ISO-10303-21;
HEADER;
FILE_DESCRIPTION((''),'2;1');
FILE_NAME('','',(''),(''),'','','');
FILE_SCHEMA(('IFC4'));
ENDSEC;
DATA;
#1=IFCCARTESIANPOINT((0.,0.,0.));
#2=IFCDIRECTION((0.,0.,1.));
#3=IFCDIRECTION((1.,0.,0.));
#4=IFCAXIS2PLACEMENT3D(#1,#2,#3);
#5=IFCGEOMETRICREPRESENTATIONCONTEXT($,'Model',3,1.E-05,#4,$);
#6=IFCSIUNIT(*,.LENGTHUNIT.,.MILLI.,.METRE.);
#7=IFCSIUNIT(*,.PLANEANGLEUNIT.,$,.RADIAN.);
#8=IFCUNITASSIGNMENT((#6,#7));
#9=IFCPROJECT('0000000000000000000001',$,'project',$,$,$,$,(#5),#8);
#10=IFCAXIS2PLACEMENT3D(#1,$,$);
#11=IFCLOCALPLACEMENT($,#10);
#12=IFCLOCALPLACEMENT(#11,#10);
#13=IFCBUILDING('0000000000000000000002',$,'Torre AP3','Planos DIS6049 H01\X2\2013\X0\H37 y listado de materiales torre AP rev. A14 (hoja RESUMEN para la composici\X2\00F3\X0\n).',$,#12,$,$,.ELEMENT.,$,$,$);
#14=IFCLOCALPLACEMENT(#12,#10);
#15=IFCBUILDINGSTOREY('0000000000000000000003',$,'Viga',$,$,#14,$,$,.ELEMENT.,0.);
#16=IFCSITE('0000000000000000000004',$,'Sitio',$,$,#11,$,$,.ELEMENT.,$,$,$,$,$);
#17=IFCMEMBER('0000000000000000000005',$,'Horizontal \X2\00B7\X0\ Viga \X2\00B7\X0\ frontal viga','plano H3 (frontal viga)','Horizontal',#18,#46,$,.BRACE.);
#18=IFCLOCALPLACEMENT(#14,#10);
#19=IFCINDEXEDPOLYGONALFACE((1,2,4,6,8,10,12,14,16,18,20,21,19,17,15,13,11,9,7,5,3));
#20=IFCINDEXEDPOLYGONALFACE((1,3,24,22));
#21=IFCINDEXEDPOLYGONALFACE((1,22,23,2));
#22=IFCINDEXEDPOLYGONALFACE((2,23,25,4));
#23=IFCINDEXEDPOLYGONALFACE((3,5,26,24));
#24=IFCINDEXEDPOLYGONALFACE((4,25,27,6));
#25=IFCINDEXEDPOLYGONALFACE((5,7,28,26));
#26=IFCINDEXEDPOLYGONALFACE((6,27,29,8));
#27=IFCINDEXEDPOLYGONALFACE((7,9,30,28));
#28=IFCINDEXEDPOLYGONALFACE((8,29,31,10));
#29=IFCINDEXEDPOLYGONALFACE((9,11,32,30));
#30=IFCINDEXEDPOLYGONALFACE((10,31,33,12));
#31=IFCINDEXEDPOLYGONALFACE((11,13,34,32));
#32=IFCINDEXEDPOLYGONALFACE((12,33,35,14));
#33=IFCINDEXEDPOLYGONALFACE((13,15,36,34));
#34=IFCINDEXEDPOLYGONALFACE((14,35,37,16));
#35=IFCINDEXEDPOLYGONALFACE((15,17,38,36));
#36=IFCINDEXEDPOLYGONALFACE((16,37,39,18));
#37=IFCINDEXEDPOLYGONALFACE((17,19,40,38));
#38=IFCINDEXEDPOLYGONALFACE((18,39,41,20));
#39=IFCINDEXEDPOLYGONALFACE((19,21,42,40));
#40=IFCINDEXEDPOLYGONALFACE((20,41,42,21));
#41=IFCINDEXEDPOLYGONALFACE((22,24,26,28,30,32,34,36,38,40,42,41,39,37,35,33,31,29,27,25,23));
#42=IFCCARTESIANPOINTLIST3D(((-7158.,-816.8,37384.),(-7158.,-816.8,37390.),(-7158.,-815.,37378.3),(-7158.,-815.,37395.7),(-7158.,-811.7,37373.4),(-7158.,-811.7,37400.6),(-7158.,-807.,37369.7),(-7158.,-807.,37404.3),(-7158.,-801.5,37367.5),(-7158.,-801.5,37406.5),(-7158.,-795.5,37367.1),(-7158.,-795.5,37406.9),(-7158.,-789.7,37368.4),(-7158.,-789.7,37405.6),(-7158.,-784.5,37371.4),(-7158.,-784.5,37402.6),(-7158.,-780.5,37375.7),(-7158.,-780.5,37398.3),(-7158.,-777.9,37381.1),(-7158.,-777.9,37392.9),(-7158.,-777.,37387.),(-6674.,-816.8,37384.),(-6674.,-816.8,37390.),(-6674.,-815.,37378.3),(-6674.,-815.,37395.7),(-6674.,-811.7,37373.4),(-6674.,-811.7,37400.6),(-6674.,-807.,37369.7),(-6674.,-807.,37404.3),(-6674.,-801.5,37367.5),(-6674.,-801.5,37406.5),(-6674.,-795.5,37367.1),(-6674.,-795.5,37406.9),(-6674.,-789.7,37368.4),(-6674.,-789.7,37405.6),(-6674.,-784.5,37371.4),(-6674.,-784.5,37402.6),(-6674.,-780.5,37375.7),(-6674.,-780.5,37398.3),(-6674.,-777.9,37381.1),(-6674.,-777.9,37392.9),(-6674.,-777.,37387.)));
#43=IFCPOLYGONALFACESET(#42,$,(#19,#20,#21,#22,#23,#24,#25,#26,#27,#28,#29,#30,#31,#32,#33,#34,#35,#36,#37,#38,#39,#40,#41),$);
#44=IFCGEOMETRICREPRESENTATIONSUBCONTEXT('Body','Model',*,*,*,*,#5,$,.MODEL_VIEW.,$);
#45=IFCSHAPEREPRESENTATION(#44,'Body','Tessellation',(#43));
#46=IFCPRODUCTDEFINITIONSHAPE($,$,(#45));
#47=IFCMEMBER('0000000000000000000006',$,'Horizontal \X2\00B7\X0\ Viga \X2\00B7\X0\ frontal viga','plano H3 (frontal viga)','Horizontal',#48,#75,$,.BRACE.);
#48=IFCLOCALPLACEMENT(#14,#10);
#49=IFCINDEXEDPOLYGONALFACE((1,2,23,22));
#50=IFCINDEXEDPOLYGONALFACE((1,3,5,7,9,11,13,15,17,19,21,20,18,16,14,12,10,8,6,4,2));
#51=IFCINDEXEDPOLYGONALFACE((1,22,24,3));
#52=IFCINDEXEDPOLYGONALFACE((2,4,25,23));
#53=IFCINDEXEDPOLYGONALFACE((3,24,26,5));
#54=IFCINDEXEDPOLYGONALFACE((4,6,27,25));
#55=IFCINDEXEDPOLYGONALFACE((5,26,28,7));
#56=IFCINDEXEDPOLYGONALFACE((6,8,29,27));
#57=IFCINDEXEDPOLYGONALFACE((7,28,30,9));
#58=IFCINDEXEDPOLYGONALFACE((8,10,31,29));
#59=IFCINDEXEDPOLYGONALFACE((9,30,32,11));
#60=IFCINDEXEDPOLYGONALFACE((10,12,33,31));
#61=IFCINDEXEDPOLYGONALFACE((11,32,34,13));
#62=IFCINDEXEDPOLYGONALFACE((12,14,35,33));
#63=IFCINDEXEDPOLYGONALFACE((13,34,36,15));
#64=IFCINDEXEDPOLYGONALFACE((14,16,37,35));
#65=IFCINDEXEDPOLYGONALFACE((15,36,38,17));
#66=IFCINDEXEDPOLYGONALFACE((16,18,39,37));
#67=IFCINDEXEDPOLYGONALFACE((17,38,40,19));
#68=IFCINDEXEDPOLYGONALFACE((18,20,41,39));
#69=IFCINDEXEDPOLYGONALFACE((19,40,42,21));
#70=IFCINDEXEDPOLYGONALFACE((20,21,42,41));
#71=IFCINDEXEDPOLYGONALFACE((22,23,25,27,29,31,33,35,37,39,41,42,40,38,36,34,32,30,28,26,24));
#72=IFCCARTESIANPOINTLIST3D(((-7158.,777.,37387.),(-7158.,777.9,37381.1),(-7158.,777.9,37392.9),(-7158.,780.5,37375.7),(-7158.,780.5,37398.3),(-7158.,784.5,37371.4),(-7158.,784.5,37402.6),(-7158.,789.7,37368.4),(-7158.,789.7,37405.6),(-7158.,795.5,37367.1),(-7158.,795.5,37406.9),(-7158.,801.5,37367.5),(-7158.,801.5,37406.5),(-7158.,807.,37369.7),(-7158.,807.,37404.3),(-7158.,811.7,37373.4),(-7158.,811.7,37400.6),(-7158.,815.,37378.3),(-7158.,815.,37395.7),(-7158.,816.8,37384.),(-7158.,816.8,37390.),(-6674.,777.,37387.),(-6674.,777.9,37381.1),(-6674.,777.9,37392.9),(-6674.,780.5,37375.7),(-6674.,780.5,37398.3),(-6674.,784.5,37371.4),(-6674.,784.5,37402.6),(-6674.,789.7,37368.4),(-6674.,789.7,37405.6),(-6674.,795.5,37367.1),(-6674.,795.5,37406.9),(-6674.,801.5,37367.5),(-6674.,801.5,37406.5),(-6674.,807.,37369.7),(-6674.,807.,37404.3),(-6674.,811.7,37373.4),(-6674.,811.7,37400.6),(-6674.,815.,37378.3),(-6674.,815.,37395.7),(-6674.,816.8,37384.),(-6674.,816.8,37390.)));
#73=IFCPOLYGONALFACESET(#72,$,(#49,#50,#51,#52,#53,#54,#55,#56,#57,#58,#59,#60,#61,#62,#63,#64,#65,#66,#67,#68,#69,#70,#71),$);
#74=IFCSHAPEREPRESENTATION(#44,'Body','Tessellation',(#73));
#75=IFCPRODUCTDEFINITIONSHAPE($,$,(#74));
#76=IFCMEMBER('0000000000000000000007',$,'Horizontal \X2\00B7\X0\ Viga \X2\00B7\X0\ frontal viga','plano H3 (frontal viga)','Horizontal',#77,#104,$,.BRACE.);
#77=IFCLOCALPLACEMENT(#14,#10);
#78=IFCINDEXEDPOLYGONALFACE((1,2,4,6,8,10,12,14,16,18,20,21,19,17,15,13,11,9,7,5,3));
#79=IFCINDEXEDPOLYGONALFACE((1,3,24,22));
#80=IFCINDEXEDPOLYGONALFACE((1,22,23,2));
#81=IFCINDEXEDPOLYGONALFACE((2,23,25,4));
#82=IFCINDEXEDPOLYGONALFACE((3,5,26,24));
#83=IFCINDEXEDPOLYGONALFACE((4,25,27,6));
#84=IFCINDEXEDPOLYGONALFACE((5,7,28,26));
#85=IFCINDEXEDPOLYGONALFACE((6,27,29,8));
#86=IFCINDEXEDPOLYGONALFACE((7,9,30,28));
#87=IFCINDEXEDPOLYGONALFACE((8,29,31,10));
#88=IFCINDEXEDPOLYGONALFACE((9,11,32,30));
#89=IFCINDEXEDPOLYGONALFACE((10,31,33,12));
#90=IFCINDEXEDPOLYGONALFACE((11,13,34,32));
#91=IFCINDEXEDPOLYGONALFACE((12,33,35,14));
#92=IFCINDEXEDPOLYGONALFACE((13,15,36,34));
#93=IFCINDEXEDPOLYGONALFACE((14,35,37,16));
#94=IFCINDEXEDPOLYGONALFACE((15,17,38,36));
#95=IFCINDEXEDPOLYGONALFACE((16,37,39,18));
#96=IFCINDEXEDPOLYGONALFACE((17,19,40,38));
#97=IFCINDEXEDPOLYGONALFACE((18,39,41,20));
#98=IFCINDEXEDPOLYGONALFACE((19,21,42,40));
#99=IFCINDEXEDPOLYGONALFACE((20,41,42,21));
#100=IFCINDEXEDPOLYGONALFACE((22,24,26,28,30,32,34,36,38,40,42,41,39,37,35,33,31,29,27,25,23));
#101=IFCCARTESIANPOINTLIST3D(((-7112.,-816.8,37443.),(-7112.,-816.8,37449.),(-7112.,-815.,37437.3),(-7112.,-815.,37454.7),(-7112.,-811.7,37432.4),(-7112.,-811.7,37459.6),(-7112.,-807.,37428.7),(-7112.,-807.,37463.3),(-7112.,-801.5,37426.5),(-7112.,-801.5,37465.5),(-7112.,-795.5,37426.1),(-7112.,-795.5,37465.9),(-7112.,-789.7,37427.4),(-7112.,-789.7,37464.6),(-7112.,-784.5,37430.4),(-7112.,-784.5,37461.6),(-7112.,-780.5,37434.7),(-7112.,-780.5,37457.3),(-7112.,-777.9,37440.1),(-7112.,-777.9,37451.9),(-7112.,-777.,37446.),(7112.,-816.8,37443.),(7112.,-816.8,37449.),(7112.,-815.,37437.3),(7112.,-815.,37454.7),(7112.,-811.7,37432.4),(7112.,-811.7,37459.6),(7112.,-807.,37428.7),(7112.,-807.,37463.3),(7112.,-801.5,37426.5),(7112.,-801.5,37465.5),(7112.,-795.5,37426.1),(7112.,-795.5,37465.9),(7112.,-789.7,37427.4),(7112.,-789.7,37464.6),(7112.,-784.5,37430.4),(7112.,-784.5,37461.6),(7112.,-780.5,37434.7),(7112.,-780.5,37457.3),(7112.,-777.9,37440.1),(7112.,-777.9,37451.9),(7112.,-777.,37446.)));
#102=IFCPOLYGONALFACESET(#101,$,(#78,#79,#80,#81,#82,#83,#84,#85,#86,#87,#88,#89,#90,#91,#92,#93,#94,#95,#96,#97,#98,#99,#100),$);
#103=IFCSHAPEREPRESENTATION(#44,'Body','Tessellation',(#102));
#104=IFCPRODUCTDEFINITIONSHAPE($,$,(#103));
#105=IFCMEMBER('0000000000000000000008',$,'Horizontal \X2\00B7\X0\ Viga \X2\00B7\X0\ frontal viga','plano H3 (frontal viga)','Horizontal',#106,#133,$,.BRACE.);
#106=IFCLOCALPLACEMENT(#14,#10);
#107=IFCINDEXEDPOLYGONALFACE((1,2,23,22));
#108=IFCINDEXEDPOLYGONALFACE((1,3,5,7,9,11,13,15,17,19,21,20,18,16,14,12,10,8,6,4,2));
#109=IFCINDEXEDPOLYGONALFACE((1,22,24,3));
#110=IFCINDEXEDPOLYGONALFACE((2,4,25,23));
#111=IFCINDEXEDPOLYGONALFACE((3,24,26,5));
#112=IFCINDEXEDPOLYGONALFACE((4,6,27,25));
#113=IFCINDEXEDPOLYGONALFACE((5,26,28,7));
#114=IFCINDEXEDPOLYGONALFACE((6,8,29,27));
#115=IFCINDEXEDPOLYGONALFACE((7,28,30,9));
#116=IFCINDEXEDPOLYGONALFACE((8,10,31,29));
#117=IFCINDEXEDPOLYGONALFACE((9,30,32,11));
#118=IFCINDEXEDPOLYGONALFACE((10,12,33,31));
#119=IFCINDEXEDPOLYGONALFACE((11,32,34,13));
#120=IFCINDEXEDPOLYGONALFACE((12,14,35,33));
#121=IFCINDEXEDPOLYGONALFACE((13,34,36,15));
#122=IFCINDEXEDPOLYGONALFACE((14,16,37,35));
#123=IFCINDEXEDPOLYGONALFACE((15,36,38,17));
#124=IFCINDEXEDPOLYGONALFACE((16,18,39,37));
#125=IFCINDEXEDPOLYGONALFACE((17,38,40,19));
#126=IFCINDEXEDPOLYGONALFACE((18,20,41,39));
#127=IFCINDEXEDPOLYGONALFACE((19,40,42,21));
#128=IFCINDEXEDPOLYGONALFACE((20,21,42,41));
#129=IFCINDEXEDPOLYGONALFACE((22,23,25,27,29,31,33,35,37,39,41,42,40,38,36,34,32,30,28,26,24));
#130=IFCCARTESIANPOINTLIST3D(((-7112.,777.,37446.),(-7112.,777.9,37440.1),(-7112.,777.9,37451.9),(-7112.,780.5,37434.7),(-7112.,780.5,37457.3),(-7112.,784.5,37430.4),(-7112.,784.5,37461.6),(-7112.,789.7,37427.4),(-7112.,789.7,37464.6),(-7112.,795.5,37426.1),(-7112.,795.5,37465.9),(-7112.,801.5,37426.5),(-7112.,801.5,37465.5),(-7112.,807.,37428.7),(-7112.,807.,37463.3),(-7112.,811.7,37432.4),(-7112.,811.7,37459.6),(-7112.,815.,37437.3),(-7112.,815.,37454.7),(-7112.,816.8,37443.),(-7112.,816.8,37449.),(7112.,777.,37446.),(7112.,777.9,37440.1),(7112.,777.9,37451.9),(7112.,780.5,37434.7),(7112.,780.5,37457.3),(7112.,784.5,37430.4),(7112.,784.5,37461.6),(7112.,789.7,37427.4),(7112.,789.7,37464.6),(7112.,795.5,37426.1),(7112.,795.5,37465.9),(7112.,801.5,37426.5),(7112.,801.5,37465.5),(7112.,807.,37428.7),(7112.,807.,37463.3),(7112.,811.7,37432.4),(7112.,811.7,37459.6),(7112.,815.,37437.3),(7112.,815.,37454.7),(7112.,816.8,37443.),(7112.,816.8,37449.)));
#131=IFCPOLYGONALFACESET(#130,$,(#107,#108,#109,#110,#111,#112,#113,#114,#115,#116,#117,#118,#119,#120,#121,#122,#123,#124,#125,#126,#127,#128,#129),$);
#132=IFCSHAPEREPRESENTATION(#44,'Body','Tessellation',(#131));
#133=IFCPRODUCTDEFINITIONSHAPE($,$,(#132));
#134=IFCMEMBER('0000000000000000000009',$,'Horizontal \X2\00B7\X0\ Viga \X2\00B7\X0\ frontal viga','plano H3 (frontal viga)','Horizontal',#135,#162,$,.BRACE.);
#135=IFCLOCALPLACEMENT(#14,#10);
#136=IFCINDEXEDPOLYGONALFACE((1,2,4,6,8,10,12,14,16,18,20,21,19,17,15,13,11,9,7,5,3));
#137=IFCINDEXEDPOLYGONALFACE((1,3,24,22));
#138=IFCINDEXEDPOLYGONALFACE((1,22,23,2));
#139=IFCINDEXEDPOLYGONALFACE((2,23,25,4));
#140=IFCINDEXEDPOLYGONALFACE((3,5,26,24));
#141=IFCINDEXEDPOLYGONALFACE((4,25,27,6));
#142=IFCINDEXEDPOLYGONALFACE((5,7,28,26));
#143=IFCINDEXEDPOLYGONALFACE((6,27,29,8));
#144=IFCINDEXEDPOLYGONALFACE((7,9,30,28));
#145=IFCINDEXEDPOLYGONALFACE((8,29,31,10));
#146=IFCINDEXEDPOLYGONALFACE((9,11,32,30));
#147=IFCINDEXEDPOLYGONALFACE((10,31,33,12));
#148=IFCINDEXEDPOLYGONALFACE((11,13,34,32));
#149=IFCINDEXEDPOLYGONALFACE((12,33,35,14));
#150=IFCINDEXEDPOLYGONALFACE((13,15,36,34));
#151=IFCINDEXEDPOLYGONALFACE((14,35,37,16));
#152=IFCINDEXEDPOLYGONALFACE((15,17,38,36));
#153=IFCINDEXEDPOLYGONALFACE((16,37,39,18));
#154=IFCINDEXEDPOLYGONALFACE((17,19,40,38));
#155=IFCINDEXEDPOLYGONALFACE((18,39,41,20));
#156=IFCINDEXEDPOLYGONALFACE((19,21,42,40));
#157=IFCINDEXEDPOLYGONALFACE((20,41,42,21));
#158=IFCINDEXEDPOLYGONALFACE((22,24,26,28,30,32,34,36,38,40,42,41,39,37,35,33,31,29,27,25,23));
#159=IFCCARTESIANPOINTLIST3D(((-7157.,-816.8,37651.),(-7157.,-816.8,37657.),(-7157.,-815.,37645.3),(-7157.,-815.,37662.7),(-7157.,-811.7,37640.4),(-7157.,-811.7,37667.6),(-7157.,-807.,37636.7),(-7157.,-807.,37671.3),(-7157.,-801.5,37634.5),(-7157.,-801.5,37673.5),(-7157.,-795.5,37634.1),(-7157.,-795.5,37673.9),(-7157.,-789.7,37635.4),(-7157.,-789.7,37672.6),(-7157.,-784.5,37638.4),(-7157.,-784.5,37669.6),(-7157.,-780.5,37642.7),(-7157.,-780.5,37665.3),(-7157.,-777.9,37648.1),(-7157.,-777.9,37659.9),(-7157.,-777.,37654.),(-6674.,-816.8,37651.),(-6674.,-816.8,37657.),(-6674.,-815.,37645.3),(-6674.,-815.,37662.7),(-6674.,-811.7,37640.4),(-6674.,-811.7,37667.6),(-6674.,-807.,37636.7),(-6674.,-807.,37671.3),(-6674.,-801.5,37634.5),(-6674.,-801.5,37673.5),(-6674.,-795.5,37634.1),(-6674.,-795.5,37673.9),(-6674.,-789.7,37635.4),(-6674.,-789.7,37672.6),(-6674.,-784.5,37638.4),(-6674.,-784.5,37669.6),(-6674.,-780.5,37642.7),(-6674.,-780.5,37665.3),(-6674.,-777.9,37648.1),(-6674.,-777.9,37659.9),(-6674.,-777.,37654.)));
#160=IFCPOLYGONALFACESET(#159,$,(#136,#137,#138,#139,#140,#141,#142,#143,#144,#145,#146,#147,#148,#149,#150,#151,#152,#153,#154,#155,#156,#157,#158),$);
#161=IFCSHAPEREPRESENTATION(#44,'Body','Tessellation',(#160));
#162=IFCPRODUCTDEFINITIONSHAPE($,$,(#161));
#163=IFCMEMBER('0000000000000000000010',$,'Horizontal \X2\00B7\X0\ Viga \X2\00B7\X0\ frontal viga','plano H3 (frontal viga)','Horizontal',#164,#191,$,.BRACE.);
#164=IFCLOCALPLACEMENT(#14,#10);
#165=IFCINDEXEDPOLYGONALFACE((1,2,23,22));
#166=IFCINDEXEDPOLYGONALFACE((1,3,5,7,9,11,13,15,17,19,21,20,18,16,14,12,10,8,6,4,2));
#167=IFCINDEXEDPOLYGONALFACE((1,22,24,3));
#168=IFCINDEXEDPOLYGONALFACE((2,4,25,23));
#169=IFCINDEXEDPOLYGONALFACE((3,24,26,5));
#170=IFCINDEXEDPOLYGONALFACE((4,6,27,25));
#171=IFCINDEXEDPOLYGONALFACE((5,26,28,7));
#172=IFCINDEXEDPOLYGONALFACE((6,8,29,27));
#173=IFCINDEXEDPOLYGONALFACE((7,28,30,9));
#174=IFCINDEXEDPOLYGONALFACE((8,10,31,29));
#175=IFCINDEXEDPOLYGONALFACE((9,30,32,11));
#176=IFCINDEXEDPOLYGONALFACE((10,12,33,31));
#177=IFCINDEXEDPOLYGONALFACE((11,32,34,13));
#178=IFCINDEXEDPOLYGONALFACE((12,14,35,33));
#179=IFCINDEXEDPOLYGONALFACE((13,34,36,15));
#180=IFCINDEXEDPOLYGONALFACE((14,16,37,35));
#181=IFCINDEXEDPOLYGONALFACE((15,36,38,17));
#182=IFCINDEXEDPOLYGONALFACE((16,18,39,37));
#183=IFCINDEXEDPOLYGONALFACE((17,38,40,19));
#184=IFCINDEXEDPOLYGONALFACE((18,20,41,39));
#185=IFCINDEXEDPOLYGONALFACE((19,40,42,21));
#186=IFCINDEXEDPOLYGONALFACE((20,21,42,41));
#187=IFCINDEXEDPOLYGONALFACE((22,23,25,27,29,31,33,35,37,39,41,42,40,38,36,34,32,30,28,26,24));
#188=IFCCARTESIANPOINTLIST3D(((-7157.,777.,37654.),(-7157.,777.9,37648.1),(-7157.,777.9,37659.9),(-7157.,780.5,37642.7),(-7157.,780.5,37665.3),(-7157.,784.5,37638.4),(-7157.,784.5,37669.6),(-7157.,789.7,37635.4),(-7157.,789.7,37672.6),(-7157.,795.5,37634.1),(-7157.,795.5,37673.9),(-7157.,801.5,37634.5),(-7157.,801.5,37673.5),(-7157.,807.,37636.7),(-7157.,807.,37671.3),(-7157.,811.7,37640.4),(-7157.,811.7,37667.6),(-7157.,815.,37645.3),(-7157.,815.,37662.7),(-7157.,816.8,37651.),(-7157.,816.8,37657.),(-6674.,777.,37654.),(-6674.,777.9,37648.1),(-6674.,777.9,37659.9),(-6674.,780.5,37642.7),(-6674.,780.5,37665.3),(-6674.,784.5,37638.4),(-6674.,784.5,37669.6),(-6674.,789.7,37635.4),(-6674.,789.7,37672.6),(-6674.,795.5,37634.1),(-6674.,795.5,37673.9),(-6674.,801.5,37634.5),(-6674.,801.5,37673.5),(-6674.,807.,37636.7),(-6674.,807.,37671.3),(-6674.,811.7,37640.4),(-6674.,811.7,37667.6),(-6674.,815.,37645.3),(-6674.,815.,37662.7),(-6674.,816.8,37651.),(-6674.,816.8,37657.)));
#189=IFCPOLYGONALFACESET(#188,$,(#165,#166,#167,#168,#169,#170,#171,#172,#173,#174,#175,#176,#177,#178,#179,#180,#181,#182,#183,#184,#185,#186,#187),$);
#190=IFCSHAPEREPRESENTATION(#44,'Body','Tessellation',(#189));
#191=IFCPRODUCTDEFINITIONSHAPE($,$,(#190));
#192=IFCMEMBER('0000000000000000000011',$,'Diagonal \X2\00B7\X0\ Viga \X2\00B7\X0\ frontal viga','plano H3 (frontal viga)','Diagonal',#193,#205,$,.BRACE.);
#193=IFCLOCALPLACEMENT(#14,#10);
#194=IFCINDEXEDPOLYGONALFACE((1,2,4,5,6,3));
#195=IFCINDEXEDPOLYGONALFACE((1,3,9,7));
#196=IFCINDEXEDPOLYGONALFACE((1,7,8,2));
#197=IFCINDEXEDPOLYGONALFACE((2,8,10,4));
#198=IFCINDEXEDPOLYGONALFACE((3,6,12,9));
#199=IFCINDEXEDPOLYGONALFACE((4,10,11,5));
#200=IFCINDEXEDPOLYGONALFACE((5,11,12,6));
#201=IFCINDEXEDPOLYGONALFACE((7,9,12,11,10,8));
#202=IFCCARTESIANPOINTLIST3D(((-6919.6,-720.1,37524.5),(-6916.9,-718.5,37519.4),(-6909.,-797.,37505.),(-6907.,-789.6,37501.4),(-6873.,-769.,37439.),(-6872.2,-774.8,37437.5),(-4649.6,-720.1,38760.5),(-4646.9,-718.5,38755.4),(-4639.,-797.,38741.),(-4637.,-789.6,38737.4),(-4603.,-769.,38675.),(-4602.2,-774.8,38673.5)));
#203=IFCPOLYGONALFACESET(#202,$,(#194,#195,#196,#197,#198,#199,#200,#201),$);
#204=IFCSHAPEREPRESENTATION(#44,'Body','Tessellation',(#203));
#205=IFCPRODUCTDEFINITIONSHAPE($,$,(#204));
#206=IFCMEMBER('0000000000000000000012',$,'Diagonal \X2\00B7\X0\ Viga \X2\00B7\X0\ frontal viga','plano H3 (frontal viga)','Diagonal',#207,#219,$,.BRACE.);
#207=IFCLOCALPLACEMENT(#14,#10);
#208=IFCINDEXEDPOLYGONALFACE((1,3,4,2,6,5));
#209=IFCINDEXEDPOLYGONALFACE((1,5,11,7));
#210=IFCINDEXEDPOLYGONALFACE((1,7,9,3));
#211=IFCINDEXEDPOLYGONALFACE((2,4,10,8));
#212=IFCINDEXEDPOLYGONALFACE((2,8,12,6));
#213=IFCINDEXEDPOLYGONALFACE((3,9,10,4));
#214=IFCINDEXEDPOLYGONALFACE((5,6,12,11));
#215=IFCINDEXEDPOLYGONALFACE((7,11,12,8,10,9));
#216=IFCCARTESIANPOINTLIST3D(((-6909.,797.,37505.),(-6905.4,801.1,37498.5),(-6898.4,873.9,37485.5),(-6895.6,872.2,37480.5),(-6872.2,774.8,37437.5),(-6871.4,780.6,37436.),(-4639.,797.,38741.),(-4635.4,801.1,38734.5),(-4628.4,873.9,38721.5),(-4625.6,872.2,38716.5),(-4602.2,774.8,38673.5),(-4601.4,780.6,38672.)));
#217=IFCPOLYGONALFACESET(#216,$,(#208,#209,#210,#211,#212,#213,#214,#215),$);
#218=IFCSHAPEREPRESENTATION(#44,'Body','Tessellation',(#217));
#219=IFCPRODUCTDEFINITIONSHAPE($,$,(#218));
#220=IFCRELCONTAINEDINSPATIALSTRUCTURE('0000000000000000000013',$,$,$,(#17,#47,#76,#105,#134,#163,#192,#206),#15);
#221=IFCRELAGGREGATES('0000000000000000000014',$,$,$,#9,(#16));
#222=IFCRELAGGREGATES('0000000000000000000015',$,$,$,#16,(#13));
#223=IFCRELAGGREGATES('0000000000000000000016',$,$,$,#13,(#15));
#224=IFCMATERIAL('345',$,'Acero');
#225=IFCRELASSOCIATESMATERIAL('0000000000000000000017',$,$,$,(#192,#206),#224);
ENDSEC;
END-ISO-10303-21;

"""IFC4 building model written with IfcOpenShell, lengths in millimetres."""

from ifc_helpers import new_model, si_unit, frame, frame_2d, origin, origin_with_axes, place, context, subcontext, project, spatial, circle, l_section, extrude, material, element, save


model = new_model("IFC4")

# Units and contexts
model_context = context("Model", 3, precision=1e-05, world=origin_with_axes())
body_context = subcontext(model_context, "Body", "Model", "MODEL_VIEW")
ifc_project = project(units=[si_unit("LENGTHUNIT", "METRE", prefix="MILLI"), si_unit("PLANEANGLEUNIT", "RADIAN")], contexts=[model_context])

# Site, building, storey
site_placement = place(None, origin())
site = spatial("IfcSite", under=ifc_project, at=site_placement, Name="Sitio", CompositionType="ELEMENT")
building_placement = place(site_placement, origin())
building = spatial("IfcBuilding", under=site, at=building_placement, Name="Torre AP3", Description="Planos DIS6049 H01–H37 y listado de materiales torre AP rev. A14 (hoja RESUMEN para la composición).", CompositionType="ELEMENT")
storey_placement = place(building_placement, origin())
storey = spatial("IfcBuildingStorey", under=building, at=storey_placement, Name="Viga", CompositionType="ELEMENT", Elevation=0.0)

# Members
for number, where, z_axis, x_axis, name in (
    (1, (-7158.0, -797.0, 37387.0), (1.0, 0.0, 0.0), (0.0, 1.0, 0.0), "Horizontal · Viga · frontal viga"),
    (2, (-7158.0, 797.0, 37387.0), (1.0, 0.0, 0.0), (0.0, -1.0, 0.0), "Horizontal · Viga · frontal viga"),
):
    element("IfcMember", number, at=place(storey_placement, frame(where, z_axis=z_axis, x_axis=x_axis)), inside=storey, Name=name, Description="plano H3 (frontal viga)", ObjectType="Horizontal", PredefinedType="BRACE", context=body_context, shape_type="SweptSolid", body=[
        extrude(circle(Radius=20.0), None, (0.0, 0.0, 1.0), 484.0),
    ])
for number, where, z_axis, x_axis, name in (
    (3, (-7112.0, -797.0, 37446.0), (1.0, 0.0, 0.0), (0.0, 1.0, 0.0), "Horizontal · Viga · frontal viga"),
    (4, (-7112.0, 797.0, 37446.0), (1.0, 0.0, 0.0), (0.0, -1.0, 0.0), "Horizontal · Viga · frontal viga"),
):
    element("IfcMember", number, at=place(storey_placement, frame(where, z_axis=z_axis, x_axis=x_axis)), inside=storey, Name=name, Description="plano H3 (frontal viga)", ObjectType="Horizontal", PredefinedType="BRACE", context=body_context, shape_type="SweptSolid", body=[
        extrude(circle(Radius=20.0), None, (0.0, 0.0, 1.0), 14224.0),
    ])
for number, where, z_axis, x_axis, name in (
    (5, (-7157.0, -797.0, 37654.0), (1.0, 0.0, 0.0), (0.0, 1.0, 0.0), "Horizontal · Viga · frontal viga"),
    (6, (-7157.0, 797.0, 37654.0), (1.0, 0.0, 0.0), (0.0, -1.0, 0.0), "Horizontal · Viga · frontal viga"),
):
    element("IfcMember", number, at=place(storey_placement, frame(where, z_axis=z_axis, x_axis=x_axis)), inside=storey, Name=name, Description="plano H3 (frontal viga)", ObjectType="Horizontal", PredefinedType="BRACE", context=body_context, shape_type="SweptSolid", body=[
        extrude(circle(Radius=20.0), None, (0.0, 0.0, 1.0), 483.0),
    ])
ifc_material_1 = material(Name="345", Category="Acero")
for number, where, z_axis, x_axis, name in (
    (7, (-6909.0, -797.0, 37505.0), (0.87825, 0.0, 0.478201), (0.459444, 0.277327, -0.843801), "Diagonal · Viga · frontal viga"),
    (8, (-6909.0, 797.0, 37505.0), (0.87825, 0.0, 0.478201), (0.459444, -0.277327, -0.843801), "Diagonal · Viga · frontal viga"),
):
    element("IfcMember", number, at=place(storey_placement, frame(where, z_axis=z_axis, x_axis=x_axis)), inside=storey, material=ifc_material_1, Name=name, Description="plano H3 (frontal viga)", ObjectType="Diagonal", PredefinedType="BRACE", context=body_context, shape_type="SweptSolid", body=[
        extrude(l_section(Depth=80.0, Width=80.0, Thickness=6.0, at=frame_2d((40.0, 40.0))), None, (0.0, 0.0, 1.0), 2584.7),
    ])

save(model, "model.ifc")
